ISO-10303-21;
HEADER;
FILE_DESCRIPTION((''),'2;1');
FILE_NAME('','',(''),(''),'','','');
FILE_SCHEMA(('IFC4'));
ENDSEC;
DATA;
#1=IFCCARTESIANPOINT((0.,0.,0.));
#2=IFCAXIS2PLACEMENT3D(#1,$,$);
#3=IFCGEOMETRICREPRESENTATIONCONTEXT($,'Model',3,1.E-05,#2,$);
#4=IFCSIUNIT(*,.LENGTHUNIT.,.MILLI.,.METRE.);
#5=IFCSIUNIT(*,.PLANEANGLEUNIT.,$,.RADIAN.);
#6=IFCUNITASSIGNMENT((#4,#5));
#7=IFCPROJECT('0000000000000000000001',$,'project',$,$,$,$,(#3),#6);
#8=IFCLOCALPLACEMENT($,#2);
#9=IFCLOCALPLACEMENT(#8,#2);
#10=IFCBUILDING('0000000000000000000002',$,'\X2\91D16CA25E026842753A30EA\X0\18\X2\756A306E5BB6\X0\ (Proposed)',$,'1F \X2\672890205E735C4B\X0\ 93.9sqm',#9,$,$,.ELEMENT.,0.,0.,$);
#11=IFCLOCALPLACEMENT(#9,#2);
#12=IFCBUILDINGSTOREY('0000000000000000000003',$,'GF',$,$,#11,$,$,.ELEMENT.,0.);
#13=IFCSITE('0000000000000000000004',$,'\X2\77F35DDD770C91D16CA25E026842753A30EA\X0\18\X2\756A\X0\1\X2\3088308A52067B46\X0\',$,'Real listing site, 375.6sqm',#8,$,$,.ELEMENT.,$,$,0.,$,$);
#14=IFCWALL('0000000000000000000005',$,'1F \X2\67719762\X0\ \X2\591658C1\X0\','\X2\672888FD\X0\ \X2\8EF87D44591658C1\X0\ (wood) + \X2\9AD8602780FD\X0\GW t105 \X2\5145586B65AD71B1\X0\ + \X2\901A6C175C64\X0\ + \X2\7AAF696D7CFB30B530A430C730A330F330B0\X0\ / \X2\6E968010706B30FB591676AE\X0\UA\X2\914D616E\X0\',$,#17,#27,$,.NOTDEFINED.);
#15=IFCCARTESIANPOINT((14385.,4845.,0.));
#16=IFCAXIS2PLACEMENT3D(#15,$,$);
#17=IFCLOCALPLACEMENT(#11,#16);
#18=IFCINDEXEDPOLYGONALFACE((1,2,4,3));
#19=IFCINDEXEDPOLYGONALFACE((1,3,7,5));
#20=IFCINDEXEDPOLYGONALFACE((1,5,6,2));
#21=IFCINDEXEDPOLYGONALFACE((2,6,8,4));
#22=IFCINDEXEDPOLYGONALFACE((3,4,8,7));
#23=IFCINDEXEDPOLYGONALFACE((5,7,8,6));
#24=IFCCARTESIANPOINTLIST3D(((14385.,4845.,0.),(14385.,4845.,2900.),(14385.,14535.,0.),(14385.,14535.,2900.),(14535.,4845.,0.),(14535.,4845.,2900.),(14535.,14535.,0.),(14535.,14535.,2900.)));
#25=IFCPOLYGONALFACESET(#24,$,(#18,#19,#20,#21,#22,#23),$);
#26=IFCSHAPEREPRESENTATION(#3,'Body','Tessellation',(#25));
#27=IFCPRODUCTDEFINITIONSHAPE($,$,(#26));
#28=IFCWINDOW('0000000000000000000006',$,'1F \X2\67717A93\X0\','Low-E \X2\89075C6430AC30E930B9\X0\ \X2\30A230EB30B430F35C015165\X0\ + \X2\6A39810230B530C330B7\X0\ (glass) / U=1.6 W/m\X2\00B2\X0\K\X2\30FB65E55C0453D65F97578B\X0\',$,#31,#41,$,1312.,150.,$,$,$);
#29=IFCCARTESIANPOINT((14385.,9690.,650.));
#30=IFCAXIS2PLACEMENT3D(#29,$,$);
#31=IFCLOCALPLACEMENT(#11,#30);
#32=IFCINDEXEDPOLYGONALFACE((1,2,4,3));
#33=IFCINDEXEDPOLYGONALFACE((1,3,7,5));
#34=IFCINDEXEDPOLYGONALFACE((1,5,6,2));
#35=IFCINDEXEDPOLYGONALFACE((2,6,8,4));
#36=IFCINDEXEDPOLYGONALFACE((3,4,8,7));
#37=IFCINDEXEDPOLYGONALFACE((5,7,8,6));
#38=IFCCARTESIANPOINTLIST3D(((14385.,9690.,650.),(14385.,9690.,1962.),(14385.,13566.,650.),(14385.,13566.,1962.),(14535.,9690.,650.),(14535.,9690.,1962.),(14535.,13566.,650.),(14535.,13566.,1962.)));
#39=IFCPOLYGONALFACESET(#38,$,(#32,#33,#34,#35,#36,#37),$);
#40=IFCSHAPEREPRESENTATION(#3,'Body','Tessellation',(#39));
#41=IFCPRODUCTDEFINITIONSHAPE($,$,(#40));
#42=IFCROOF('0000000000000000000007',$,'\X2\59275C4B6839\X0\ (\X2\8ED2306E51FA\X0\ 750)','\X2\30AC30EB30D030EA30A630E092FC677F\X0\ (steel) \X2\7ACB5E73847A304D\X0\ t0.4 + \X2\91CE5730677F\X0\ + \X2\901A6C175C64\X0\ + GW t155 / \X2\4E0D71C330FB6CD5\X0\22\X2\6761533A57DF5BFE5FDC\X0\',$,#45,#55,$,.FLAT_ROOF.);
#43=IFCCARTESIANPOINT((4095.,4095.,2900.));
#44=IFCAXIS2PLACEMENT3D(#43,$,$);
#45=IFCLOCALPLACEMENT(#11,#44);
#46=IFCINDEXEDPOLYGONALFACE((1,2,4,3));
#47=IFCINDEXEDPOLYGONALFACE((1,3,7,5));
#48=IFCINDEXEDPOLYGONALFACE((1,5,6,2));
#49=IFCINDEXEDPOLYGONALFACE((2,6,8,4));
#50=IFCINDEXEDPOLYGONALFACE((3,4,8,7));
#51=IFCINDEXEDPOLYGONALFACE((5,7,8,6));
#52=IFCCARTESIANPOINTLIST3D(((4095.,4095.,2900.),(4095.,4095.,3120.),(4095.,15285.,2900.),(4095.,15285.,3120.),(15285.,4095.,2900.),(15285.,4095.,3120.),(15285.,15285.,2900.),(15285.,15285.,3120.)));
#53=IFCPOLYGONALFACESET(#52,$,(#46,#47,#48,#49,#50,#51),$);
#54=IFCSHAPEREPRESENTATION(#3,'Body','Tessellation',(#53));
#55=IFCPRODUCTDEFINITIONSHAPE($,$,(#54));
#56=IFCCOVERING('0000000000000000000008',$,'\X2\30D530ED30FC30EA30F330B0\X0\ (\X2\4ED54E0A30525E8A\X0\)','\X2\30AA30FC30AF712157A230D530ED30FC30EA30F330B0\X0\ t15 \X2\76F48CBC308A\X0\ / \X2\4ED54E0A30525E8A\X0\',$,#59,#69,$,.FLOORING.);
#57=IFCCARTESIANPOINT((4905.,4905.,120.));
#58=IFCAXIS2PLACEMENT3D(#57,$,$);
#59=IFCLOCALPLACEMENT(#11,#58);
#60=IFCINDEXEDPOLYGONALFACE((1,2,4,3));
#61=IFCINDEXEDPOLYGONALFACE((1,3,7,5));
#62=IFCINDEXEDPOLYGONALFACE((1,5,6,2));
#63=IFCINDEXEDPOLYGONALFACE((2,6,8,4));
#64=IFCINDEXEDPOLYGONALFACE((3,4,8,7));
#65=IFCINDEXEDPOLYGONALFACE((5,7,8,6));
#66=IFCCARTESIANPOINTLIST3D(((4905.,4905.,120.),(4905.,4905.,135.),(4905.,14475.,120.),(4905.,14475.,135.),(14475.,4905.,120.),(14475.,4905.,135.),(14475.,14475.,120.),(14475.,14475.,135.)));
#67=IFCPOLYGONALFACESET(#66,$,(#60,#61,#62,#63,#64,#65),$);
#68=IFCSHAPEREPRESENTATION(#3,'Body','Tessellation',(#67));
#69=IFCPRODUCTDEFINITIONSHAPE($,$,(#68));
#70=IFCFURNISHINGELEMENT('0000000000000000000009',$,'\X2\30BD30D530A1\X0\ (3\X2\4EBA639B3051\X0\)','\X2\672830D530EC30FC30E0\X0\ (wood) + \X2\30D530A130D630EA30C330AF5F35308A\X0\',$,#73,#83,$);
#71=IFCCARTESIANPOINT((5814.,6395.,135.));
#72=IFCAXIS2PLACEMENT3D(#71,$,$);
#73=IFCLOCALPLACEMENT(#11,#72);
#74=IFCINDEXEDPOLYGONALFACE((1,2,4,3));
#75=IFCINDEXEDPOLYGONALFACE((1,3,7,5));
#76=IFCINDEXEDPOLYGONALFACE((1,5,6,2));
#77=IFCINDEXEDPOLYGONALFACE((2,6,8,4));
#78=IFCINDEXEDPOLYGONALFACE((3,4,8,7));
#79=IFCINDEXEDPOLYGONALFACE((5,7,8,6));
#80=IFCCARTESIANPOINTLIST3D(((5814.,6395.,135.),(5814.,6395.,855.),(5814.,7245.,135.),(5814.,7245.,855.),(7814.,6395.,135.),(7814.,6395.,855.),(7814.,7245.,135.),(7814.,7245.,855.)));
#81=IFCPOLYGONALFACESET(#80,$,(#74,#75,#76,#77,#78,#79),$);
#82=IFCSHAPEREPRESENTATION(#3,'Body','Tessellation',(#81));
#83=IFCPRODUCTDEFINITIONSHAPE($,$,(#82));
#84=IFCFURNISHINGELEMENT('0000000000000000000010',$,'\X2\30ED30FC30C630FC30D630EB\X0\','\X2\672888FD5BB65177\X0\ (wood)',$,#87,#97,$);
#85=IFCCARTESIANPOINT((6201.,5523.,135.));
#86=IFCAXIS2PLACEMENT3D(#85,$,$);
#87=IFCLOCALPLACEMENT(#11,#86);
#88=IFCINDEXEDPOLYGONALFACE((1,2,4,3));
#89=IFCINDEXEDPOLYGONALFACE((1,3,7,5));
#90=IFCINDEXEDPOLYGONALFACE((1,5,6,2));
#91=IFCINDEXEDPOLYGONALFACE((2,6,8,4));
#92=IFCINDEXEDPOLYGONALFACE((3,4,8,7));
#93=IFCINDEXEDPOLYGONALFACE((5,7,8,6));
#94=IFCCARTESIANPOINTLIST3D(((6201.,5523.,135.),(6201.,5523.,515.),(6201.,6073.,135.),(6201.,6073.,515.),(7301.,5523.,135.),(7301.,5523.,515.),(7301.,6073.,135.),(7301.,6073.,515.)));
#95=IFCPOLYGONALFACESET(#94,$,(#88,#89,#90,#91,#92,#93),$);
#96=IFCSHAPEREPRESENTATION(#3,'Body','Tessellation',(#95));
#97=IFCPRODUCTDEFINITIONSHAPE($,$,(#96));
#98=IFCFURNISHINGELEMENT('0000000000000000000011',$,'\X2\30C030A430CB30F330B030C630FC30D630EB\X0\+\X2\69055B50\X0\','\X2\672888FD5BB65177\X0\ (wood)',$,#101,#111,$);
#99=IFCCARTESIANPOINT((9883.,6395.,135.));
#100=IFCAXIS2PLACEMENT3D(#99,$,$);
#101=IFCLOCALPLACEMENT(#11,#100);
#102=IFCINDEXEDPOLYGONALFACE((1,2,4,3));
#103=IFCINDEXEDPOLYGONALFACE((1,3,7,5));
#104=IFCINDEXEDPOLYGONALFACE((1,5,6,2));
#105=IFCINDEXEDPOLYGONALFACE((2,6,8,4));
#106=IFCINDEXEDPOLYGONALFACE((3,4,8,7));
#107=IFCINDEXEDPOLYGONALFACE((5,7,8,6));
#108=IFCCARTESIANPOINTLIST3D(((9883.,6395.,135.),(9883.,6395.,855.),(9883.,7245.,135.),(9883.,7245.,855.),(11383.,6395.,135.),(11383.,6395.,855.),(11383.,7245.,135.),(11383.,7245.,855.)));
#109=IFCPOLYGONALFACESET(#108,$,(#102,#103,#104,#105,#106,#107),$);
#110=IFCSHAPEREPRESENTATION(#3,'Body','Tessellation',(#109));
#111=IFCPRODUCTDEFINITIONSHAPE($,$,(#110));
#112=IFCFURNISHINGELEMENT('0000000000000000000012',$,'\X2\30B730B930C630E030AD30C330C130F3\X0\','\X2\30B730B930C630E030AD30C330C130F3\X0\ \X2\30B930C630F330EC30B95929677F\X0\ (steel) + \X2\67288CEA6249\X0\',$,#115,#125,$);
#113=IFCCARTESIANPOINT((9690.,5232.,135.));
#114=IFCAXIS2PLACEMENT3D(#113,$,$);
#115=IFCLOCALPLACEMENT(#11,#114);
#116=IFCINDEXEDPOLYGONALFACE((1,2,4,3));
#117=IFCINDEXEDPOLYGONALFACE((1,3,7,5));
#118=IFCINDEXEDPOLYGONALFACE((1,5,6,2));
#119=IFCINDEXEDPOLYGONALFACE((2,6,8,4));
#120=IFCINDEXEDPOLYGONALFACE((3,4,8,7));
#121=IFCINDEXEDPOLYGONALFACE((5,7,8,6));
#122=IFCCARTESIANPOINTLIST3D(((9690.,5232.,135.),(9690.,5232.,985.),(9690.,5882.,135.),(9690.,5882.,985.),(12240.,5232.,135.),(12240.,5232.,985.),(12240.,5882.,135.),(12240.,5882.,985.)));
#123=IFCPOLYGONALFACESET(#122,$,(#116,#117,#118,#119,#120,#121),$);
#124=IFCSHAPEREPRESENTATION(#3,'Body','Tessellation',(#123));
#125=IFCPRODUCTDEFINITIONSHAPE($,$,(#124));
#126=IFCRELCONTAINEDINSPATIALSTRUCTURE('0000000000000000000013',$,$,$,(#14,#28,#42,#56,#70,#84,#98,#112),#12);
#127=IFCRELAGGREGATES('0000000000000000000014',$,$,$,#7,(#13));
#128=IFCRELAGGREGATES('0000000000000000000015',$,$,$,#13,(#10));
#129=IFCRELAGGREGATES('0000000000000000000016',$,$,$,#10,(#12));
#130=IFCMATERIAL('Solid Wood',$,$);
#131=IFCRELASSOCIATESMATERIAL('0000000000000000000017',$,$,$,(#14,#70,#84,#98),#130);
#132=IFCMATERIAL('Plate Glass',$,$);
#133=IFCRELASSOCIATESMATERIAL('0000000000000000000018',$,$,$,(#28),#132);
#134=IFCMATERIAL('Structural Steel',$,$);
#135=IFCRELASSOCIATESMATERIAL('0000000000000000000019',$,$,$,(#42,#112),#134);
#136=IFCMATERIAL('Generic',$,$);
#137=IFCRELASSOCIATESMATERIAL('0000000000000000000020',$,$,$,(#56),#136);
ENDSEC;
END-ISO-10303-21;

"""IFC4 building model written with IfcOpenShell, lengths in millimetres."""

from ifc_helpers import new_model, si_unit, frame, frame_2d, origin, place, context, project, spatial, rectangle, extrude, material, element, fill, save


model = new_model("IFC4")

# Units and contexts
model_context = context("Model", 3, precision=1e-05, world=origin())
ifc_project = project(units=[si_unit("LENGTHUNIT", "METRE", prefix="MILLI"), si_unit("PLANEANGLEUNIT", "RADIAN")], contexts=[model_context])

# Site, building, storey
site_placement = place(None, origin())
site = spatial("IfcSite", under=ifc_project, at=site_placement, Name="石川県金沢市桂町リ18番1より分筆", ObjectType="Real listing site, 375.6sqm", CompositionType="ELEMENT", RefElevation=0.0)
building_placement = place(site_placement, origin())
building = spatial("IfcBuilding", under=site, at=building_placement, Name="金沢市桂町リ18番の家 (Proposed)", ObjectType="1F 木造平屋 93.9sqm", CompositionType="ELEMENT", ElevationOfRefHeight=0.0, ElevationOfTerrain=0.0)
storey_placement = place(building_placement, origin())
storey = spatial("IfcBuildingStorey", under=building, at=storey_placement, Name="GF", CompositionType="ELEMENT", Elevation=0.0)

# Shared definitions
ifc_material_1 = material(Name="Solid Wood")

# Shared definitions
ifc_material_2 = material(Name="Plate Glass")

# Wall, opening, window
wall_1_placement = place(storey_placement, frame((14385.0, 4845.0, 0.0)))
wall_1 = element("IfcWall", 1, at=wall_1_placement, inside=storey, material=ifc_material_1, Name="1F 東面 外壁", Description="木製 軸組外壁 (wood) + 高性能GW t105 充填断熱 + 通気層 + 窯業系サイディング / 準耐火・外皮UA配慮", PredefinedType="NOTDEFINED", context=model_context, shape_type="SweptSolid", body=[
    extrude(rectangle(XDim=150.0, YDim=9690.0, at=frame_2d((75.0, 4845.0))), frame((14385.0, 4845.0, 0.0)), (0.0, 0.0, 1.0), 2900.0),
])
opening_1_placement = place(storey_placement, frame((14385.0, 9690.0, 650.0)))
opening_1 = element("IfcOpeningElement", 2, at=opening_1_placement, cuts=wall_1, PredefinedType="NOTDEFINED", context=model_context, shape_type="SweptSolid", body=[
    extrude(rectangle(XDim=150.0, YDim=3876.0, at=frame_2d((75.0, 1938.0))), frame((14385.0, 9690.0, 650.0)), (0.0, 0.0, 1.0), 1312.0),
])
window_1_placement = place(storey_placement, frame((14385.0, 9690.0, 650.0)))
window_1 = element("IfcWindow", 3, at=window_1_placement, inside=storey, material=ifc_material_2, Name="1F 東窓", Description="Low-E 複層ガラス アルゴン封入 + 樹脂サッシ (glass) / U=1.6 W/m²K・日射取得型", OverallHeight=1312.0, OverallWidth=150.0, context=model_context, shape_type="SweptSolid", body=[
    extrude(rectangle(XDim=150.0, YDim=3876.0, at=frame_2d((75.0, 1938.0))), frame((14385.0, 9690.0, 650.0)), (0.0, 0.0, 1.0), 1312.0),
])
fill(opening_1, window_1)

# Roof
ifc_material_3 = material(Name="Structural Steel")
roof_placement = place(storey_placement, frame((4095.0, 4095.0, 2900.0)))
element("IfcRoof", 4, at=roof_placement, inside=storey, material=ifc_material_3, Name="大屋根 (軒の出 750)", Description="ガルバリウム鋼板 (steel) 立平葺き t0.4 + 野地板 + 通気層 + GW t155 / 不燃・法22条区域対応", PredefinedType="FLAT_ROOF", context=model_context, shape_type="SweptSolid", body=[
    extrude(rectangle(XDim=11190.0, YDim=11190.0, at=frame_2d((5595.0, 5595.0))), frame((4095.0, 4095.0, 2900.0)), (0.0, 0.0, 1.0), 220.0),
])

# Covering
ifc_material_4 = material(Name="Generic")
covering_placement = place(storey_placement, frame((4905.0, 4905.0, 120.0)))
element("IfcCovering", 5, at=covering_placement, inside=storey, material=ifc_material_4, Name="フローリング (仕上げ床)", Description="オーク無垢フローリング t15 直貼り / 仕上げ床", PredefinedType="FLOORING", context=model_context, shape_type="SweptSolid", body=[
    extrude(rectangle(XDim=9570.0, YDim=9570.0, at=frame_2d((4785.0, 4785.0))), frame((4905.0, 4905.0, 120.0)), (0.0, 0.0, 1.0), 15.0),
])

# Furnishing elements
furnishing_1_placement = place(storey_placement, frame((5814.0, 6395.0, 135.0)))
element("IfcFurnishingElement", 6, at=furnishing_1_placement, inside=storey, material=ifc_material_1, Name="ソファ (3人掛け)", Description="木フレーム (wood) + ファブリック張り", context=model_context, shape_type="SweptSolid", body=[
    extrude(rectangle(XDim=2000.0, YDim=850.0, at=frame_2d((1000.0, 425.0))), frame((5814.0, 6395.0, 135.0)), (0.0, 0.0, 1.0), 720.0),
])
furnishing_2_placement = place(storey_placement, frame((6201.0, 5523.0, 135.0)))
element("IfcFurnishingElement", 7, at=furnishing_2_placement, inside=storey, material=ifc_material_1, Name="ローテーブル", Description="木製家具 (wood)", context=model_context, shape_type="SweptSolid", body=[
    extrude(rectangle(XDim=1100.0, YDim=550.0, at=frame_2d((550.0, 275.0))), frame((6201.0, 5523.0, 135.0)), (0.0, 0.0, 1.0), 380.0),
])
furnishing_3_placement = place(storey_placement, frame((9883.0, 6395.0, 135.0)))
element("IfcFurnishingElement", 8, at=furnishing_3_placement, inside=storey, material=ifc_material_1, Name="ダイニングテーブル+椅子", Description="木製家具 (wood)", context=model_context, shape_type="SweptSolid", body=[
    extrude(rectangle(XDim=1500.0, YDim=850.0, at=frame_2d((750.0, 425.0))), frame((9883.0, 6395.0, 135.0)), (0.0, 0.0, 1.0), 720.0),
])
furnishing_4_placement = place(storey_placement, frame((9690.0, 5232.0, 135.0)))
element("IfcFurnishingElement", 9, at=furnishing_4_placement, inside=storey, material=ifc_material_3, Name="システムキッチン", Description="システムキッチン ステンレス天板 (steel) + 木質扉", context=model_context, shape_type="SweptSolid", body=[
    extrude(rectangle(XDim=2550.0, YDim=650.0, at=frame_2d((1275.0, 325.0))), frame((9690.0, 5232.0, 135.0)), (0.0, 0.0, 1.0), 850.0),
])

save(model, "model.ifc")
